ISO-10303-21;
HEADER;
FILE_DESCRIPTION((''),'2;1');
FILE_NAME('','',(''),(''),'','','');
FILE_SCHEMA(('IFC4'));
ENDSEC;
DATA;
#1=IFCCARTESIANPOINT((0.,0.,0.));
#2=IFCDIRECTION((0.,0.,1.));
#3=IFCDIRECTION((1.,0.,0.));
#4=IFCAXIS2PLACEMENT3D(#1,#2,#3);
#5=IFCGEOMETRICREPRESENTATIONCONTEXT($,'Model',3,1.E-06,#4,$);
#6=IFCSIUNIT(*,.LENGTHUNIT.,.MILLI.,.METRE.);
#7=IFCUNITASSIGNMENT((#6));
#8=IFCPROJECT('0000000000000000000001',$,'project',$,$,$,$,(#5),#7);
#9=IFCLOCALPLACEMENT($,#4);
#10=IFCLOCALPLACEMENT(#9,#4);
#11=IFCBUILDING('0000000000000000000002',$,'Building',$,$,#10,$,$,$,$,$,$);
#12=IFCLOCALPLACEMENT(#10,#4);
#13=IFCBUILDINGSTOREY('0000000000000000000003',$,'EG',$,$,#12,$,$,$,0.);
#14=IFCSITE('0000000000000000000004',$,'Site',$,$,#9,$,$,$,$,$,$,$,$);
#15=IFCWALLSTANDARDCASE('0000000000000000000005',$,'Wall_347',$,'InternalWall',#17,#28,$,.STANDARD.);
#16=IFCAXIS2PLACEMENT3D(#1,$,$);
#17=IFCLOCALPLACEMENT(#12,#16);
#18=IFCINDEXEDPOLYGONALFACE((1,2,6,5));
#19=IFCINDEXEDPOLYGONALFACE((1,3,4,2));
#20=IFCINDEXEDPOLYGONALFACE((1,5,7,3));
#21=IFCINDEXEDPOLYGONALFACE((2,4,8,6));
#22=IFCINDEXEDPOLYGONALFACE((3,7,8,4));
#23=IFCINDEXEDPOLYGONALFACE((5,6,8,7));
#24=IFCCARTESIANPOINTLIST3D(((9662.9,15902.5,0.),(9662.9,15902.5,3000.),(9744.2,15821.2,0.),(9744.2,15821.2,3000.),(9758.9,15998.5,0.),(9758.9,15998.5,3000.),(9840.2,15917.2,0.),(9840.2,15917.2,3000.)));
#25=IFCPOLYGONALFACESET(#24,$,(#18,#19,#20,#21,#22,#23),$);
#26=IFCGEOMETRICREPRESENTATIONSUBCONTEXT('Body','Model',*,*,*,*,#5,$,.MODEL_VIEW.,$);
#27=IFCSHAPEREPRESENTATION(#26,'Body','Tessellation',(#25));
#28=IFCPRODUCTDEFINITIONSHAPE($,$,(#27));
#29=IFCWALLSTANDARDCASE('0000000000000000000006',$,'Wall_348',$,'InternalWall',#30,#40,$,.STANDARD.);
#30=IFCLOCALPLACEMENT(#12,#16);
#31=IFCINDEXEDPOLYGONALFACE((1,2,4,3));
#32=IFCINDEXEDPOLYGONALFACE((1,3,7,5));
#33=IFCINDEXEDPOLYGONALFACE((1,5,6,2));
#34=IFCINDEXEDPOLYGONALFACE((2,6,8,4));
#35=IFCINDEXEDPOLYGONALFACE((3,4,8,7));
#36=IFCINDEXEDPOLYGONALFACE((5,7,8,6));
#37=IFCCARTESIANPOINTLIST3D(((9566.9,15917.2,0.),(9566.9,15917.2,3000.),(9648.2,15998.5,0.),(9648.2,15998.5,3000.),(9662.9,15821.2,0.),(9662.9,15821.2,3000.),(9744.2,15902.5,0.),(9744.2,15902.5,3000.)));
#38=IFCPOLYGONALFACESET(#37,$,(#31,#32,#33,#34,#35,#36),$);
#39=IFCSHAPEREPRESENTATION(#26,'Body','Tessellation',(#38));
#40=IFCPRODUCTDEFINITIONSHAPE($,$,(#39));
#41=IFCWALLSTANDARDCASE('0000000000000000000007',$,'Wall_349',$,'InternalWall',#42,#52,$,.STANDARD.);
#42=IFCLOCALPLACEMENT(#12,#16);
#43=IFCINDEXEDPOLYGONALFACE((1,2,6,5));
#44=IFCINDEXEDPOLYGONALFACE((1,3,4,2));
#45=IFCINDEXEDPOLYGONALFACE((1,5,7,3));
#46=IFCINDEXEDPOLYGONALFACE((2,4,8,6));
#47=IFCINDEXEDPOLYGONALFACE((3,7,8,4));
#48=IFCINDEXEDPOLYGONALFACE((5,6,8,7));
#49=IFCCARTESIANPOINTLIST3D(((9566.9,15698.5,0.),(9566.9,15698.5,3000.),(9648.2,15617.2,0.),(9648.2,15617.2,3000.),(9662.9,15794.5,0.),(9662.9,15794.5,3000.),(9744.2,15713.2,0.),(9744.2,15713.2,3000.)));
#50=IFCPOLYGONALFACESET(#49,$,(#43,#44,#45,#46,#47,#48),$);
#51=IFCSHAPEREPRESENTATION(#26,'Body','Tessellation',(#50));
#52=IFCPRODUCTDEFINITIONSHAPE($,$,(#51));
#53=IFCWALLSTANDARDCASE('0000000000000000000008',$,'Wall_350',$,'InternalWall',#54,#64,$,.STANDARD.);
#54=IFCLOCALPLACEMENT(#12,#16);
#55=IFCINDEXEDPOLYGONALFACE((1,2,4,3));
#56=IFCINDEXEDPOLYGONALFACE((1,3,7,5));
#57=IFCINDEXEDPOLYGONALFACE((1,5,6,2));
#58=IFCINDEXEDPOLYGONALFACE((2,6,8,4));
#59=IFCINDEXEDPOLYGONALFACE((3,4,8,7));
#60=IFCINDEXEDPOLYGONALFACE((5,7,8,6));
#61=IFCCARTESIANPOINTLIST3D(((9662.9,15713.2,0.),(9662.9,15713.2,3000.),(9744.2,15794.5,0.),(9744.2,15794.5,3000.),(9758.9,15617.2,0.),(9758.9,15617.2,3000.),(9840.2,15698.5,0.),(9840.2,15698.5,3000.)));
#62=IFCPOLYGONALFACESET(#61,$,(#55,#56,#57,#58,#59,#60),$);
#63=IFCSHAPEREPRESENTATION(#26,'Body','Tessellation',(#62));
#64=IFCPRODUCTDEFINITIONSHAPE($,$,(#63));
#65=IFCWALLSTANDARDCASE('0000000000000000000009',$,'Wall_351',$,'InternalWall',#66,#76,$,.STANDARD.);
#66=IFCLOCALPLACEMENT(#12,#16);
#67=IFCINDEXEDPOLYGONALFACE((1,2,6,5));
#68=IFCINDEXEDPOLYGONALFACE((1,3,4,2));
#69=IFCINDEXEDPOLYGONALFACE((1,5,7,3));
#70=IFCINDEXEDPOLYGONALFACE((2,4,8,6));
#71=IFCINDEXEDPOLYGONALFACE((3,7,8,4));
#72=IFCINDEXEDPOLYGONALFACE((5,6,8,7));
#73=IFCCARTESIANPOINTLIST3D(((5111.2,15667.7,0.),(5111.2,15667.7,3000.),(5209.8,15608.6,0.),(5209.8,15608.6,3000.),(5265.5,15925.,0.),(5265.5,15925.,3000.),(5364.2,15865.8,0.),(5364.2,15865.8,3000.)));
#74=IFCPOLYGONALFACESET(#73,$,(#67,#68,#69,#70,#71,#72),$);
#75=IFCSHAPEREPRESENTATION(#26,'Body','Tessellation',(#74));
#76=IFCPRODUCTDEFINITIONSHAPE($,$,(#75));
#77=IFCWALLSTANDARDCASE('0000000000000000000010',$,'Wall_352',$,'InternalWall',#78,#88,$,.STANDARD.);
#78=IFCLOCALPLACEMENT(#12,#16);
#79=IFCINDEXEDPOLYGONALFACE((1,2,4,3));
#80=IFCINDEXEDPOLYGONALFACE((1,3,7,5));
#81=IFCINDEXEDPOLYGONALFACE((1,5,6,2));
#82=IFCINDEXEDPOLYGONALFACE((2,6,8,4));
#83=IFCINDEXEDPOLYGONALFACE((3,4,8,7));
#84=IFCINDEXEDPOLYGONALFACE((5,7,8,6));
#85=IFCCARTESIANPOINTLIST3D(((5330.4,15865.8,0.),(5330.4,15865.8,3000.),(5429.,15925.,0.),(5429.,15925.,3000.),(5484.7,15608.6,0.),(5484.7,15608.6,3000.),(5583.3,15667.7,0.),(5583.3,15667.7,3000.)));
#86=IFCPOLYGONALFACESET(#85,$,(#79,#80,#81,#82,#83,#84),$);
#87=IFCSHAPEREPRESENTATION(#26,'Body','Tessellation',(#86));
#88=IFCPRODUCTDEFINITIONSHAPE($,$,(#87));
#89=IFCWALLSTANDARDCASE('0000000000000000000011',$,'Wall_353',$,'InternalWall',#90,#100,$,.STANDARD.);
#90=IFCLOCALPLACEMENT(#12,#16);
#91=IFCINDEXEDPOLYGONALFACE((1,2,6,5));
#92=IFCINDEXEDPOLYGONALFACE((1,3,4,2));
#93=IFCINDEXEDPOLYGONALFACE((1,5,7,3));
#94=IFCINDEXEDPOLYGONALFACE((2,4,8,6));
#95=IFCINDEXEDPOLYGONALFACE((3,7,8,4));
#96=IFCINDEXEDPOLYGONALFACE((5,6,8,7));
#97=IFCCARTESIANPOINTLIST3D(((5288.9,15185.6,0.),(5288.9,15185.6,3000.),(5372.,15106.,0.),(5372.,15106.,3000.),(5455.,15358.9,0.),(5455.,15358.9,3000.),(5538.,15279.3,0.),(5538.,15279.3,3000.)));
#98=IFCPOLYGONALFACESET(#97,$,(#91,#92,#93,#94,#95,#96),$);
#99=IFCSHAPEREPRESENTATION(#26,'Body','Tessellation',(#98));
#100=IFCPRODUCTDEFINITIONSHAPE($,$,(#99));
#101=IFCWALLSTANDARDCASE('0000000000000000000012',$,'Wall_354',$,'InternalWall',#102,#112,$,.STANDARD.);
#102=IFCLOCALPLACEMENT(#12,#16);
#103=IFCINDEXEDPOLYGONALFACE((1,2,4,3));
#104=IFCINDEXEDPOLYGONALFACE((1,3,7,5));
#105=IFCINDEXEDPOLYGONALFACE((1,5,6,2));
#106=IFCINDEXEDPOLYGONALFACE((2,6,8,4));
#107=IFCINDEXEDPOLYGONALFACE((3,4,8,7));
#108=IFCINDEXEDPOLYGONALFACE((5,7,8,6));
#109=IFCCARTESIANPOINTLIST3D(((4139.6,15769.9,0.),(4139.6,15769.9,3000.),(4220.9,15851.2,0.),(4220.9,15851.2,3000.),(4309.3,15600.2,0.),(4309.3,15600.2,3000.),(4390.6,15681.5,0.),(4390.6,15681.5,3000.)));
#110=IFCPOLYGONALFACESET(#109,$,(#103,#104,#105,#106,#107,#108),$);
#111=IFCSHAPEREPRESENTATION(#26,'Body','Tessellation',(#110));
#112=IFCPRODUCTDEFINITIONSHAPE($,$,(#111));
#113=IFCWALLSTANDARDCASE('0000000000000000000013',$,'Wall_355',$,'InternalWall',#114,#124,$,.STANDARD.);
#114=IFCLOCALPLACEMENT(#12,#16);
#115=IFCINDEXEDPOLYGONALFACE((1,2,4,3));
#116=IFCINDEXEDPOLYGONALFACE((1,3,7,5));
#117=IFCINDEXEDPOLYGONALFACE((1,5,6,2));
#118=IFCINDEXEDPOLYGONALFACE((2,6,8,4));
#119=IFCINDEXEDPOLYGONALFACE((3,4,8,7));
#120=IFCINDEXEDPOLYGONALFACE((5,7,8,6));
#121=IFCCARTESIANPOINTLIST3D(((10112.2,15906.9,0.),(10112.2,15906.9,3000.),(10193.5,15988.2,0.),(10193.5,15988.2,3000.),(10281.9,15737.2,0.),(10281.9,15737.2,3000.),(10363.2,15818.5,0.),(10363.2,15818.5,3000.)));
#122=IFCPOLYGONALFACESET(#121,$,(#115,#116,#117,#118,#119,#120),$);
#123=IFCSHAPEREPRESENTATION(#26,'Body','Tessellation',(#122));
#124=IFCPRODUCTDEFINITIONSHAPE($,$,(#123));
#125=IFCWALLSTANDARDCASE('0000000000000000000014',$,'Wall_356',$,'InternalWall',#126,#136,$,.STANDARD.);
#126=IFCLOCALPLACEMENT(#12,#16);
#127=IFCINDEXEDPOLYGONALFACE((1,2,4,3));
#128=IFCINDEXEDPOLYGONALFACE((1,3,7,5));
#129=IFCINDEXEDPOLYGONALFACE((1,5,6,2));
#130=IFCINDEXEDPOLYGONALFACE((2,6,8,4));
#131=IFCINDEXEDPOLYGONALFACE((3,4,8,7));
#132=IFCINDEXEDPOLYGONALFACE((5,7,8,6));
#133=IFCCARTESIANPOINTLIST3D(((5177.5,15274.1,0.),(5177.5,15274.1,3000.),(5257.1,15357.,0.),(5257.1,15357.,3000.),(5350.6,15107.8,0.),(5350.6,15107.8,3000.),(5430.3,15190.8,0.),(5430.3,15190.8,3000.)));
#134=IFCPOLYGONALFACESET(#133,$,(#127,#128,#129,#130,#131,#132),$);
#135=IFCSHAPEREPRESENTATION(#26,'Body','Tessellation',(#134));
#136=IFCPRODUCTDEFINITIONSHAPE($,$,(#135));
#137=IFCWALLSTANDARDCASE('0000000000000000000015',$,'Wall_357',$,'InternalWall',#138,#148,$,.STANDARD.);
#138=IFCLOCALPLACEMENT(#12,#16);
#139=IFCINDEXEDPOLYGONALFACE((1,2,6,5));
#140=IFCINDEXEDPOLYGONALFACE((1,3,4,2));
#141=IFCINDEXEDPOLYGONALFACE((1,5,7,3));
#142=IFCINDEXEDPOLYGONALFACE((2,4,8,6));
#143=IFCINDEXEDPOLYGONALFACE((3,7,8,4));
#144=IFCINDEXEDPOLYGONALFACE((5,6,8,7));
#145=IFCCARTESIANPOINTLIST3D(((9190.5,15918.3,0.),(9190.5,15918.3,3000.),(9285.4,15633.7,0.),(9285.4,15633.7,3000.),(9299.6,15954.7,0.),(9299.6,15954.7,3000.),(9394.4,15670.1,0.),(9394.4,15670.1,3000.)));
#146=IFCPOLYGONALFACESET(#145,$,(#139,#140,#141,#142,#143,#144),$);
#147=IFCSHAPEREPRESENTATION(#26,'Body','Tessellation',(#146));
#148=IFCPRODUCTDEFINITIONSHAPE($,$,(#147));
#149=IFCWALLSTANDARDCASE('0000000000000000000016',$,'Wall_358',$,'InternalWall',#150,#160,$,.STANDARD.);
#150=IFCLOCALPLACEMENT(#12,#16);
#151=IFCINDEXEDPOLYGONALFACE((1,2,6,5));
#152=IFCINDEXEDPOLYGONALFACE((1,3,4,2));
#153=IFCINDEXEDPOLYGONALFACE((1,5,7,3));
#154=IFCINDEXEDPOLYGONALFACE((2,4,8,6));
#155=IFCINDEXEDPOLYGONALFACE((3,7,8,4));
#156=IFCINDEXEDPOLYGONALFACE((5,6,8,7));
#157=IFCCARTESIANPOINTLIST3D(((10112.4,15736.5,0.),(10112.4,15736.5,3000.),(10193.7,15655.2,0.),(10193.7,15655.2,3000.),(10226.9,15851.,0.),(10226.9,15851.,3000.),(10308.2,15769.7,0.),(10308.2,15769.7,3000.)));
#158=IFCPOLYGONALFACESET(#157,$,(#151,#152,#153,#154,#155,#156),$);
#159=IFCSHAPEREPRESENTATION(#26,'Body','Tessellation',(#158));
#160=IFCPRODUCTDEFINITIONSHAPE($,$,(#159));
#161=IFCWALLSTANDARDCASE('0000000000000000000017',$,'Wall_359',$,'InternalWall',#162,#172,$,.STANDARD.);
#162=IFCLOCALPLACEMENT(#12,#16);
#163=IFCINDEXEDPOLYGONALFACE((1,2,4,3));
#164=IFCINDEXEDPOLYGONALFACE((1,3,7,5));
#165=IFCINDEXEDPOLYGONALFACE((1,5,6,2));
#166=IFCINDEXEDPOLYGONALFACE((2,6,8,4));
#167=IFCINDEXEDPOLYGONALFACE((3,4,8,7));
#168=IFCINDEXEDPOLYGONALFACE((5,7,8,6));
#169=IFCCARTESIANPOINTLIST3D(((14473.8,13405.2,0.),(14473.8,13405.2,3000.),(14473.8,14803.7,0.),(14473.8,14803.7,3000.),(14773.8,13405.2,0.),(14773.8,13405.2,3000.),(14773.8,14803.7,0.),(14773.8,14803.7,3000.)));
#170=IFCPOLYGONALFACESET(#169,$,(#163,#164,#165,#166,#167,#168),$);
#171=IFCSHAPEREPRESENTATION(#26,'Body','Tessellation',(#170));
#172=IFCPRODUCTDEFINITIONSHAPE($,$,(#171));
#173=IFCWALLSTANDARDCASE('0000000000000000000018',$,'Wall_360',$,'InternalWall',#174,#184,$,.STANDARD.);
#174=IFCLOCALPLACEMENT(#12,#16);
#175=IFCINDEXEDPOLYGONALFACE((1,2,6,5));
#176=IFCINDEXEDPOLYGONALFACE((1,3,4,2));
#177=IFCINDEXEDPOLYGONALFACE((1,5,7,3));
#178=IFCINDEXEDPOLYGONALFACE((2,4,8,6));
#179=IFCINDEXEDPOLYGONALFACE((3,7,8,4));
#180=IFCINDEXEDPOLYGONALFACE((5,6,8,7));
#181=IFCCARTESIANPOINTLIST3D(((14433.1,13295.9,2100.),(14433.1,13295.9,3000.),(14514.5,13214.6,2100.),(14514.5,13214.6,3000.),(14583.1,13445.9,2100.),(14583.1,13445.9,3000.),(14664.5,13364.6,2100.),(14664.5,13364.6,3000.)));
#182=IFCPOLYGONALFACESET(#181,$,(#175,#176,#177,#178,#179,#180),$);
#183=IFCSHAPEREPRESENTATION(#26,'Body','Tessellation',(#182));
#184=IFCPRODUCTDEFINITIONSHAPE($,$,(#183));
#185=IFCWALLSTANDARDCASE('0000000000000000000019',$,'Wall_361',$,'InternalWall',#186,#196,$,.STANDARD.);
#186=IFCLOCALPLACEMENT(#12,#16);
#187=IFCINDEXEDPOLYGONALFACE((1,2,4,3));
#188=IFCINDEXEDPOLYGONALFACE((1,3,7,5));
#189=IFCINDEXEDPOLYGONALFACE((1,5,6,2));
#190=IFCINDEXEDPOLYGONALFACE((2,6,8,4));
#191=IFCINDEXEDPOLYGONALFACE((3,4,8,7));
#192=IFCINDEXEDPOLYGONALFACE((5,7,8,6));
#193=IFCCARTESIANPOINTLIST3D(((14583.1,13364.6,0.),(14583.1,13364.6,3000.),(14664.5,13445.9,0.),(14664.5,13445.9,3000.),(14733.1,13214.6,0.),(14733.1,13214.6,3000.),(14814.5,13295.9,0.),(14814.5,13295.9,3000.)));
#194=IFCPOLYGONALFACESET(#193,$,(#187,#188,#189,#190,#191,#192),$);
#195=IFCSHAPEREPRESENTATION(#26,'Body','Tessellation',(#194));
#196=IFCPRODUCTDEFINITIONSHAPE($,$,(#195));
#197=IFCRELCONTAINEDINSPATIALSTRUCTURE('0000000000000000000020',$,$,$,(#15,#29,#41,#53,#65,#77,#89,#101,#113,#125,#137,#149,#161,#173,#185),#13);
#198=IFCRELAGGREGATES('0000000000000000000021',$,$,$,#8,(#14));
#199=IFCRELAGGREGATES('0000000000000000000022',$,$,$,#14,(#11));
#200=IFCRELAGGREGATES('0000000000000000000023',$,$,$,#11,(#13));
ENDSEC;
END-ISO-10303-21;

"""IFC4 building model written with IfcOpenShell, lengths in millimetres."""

from ifc_helpers import new_model, si_unit, frame, origin_with_axes, place, context, subcontext, project, spatial, rectangle, extrude, element, save


model = new_model("IFC4")

# Units and contexts
model_context = context("Model", 3, precision=1e-06, world=origin_with_axes())
body_context = subcontext(model_context, "Body", "Model", "MODEL_VIEW")
ifc_project = project(units=[si_unit("LENGTHUNIT", "METRE", prefix="MILLI")], contexts=[model_context])

# Site, building, storey
site_placement = place(None, origin_with_axes())
site = spatial("IfcSite", under=ifc_project, at=site_placement, Name="Site")
building_placement = place(site_placement, origin_with_axes())
building = spatial("IfcBuilding", under=site, at=building_placement, Name="Building")
storey_placement = place(building_placement, origin_with_axes())
storey = spatial("IfcBuildingStorey", under=building, at=storey_placement, Name="EG", Elevation=0.0)

# Walls
wall_1_placement = place(storey_placement, origin_with_axes())
element("IfcWallStandardCase", 1, at=wall_1_placement, inside=storey, Name="Wall_347", ObjectType="InternalWall", PredefinedType="STANDARD", context=body_context, shape_type="SweptSolid", body=[
    extrude(rectangle(XDim=135.8, YDim=115.0), frame((9751.5, 15909.9, 0.0), z_axis=(0.0, 0.0, 1.0), x_axis=(-0.707107, -0.707107, 0.0)), (0.0, 0.0, 1.0), 3000.0),
])
wall_2_placement = place(storey_placement, origin_with_axes())
element("IfcWallStandardCase", 2, at=wall_2_placement, inside=storey, Name="Wall_348", ObjectType="InternalWall", PredefinedType="STANDARD", context=body_context, shape_type="SweptSolid", body=[
    extrude(rectangle(XDim=135.8, YDim=115.0), frame((9655.5, 15909.9, 0.0), z_axis=(0.0, 0.0, 1.0), x_axis=(-0.707107, 0.707107, 0.0)), (0.0, 0.0, 1.0), 3000.0),
])
wall_3_placement = place(storey_placement, origin_with_axes())
element("IfcWallStandardCase", 3, at=wall_3_placement, inside=storey, Name="Wall_349", ObjectType="InternalWall", PredefinedType="STANDARD", context=body_context, shape_type="SweptSolid", body=[
    extrude(rectangle(XDim=135.8, YDim=115.0), frame((9655.5, 15705.9, 0.0), z_axis=(0.0, 0.0, 1.0), x_axis=(-0.707107, -0.707107, 0.0)), (0.0, 0.0, 1.0), 3000.0),
])
wall_4_placement = place(storey_placement, origin_with_axes())
element("IfcWallStandardCase", 4, at=wall_4_placement, inside=storey, Name="Wall_350", ObjectType="InternalWall", PredefinedType="STANDARD", context=body_context, shape_type="SweptSolid", body=[
    extrude(rectangle(XDim=135.8, YDim=115.0), frame((9751.5, 15705.9, 0.0), z_axis=(0.0, 0.0, 1.0), x_axis=(0.707107, -0.707107, 0.0)), (0.0, 0.0, 1.0), 3000.0),
])
wall_5_placement = place(storey_placement, origin_with_axes())
element("IfcWallStandardCase", 5, at=wall_5_placement, inside=storey, Name="Wall_351", ObjectType="InternalWall", PredefinedType="STANDARD", context=body_context, shape_type="SweptSolid", body=[
    extrude(rectangle(XDim=300.0, YDim=115.0), frame((5237.7, 15766.8, 0.0), z_axis=(0.0, 0.0, 1.0), x_axis=(0.514496, 0.857493, 0.0)), (0.0, 0.0, 1.0), 3000.0),
])
wall_6_placement = place(storey_placement, origin_with_axes())
element("IfcWallStandardCase", 6, at=wall_6_placement, inside=storey, Name="Wall_352", ObjectType="InternalWall", PredefinedType="STANDARD", context=body_context, shape_type="SweptSolid", body=[
    extrude(rectangle(XDim=300.0, YDim=115.0), frame((5456.8, 15766.8, 0.0), z_axis=(0.0, 0.0, 1.0), x_axis=(-0.514496, 0.857493, 0.0)), (0.0, 0.0, 1.0), 3000.0),
])
wall_7_placement = place(storey_placement, origin_with_axes())
element("IfcWallStandardCase", 7, at=wall_7_placement, inside=storey, Name="Wall_353", ObjectType="InternalWall", PredefinedType="STANDARD", context=body_context, shape_type="SweptSolid", body=[
    extrude(rectangle(XDim=240.0, YDim=115.0), frame((5413.5, 15232.4, 0.0), z_axis=(0.0, 0.0, 1.0), x_axis=(0.69185, 0.722042, 0.0)), (0.0, 0.0, 1.0), 3000.0),
])
wall_8_placement = place(storey_placement, origin_with_axes())
element("IfcWallStandardCase", 8, at=wall_8_placement, inside=storey, Name="Wall_354", ObjectType="InternalWall", PredefinedType="STANDARD", context=body_context, shape_type="SweptSolid", body=[
    extrude(rectangle(XDim=240.0, YDim=115.0), frame((4265.1, 15725.7, 0.0), z_axis=(0.0, 0.0, 1.0), x_axis=(0.707107, -0.707107, 0.0)), (0.0, 0.0, 1.0), 3000.0),
])
wall_9_placement = place(storey_placement, origin_with_axes())
element("IfcWallStandardCase", 9, at=wall_9_placement, inside=storey, Name="Wall_355", ObjectType="InternalWall", PredefinedType="STANDARD", context=body_context, shape_type="SweptSolid", body=[
    extrude(rectangle(XDim=240.0, YDim=115.0), frame((10237.7, 15862.7, 0.0), z_axis=(0.0, 0.0, 1.0), x_axis=(-0.707107, 0.707107, 0.0)), (0.0, 0.0, 1.0), 3000.0),
])
wall_10_placement = place(storey_placement, origin_with_axes())
element("IfcWallStandardCase", 10, at=wall_10_placement, inside=storey, Name="Wall_356", ObjectType="InternalWall", PredefinedType="STANDARD", context=body_context, shape_type="SweptSolid", body=[
    extrude(rectangle(XDim=240.0, YDim=115.0), frame((5303.9, 15232.4, 0.0), z_axis=(0.0, 0.0, 1.0), x_axis=(-0.721334, 0.692587, 0.0)), (0.0, 0.0, 1.0), 3000.0),
])
wall_11_placement = place(storey_placement, origin_with_axes())
element("IfcWallStandardCase", 11, at=wall_11_placement, inside=storey, Name="Wall_357", ObjectType="InternalWall", PredefinedType="STANDARD", context=body_context, shape_type="SweptSolid", body=[
    extrude(rectangle(XDim=300.0, YDim=115.0), frame((9292.5, 15794.2, 0.0), z_axis=(0.0, 0.0, 1.0), x_axis=(-0.316228, 0.948683, 0.0)), (0.0, 0.0, 1.0), 3000.0),
])
wall_12_placement = place(storey_placement, origin_with_axes())
element("IfcWallStandardCase", 12, at=wall_12_placement, inside=storey, Name="Wall_358", ObjectType="InternalWall", PredefinedType="STANDARD", context=body_context, shape_type="SweptSolid", body=[
    extrude(rectangle(XDim=161.9, YDim=115.0), frame((10210.3, 15753.1, 0.0), z_axis=(0.0, 0.0, 1.0), x_axis=(-0.707107, -0.707107, 0.0)), (0.0, 0.0, 1.0), 3000.0),
])
wall_13_placement = place(storey_placement, origin_with_axes())
element("IfcWallStandardCase", 13, at=wall_13_placement, inside=storey, Name="Wall_359", ObjectType="InternalWall", PredefinedType="STANDARD", context=body_context, shape_type="SweptSolid", body=[
    extrude(rectangle(XDim=1398.5, YDim=300.0), frame((14623.8, 14104.5, 0.0), z_axis=(0.0, 0.0, 1.0), x_axis=(0.0, 1.0, 0.0)), (0.0, 0.0, 1.0), 3000.0),
])

# Wall, opening
wall_14_placement = place(storey_placement, origin_with_axes())
wall_14 = element("IfcWallStandardCase", 14, at=wall_14_placement, inside=storey, Name="Wall_360", ObjectType="InternalWall", PredefinedType="STANDARD", context=body_context, shape_type="SweptSolid", body=[
    extrude(rectangle(XDim=212.1, YDim=115.0), frame((14548.8, 13330.2, 0.0), z_axis=(0.0, 0.0, 1.0), x_axis=(-0.707107, -0.707107, 0.0)), (0.0, 0.0, 1.0), 3000.0),
])
opening_placement = place(wall_14_placement, origin_with_axes())
element("IfcOpeningElement", 15, at=opening_placement, inside=storey, cuts=wall_14, context=body_context, shape_type="SweptSolid", body=[
    extrude(rectangle(XDim=799.9, YDim=115.0), frame((14494.2, 13275.6, 0.0), z_axis=(0.0, 0.0, 1.0), x_axis=(-0.707107, -0.707107, 0.0)), (0.0, 0.0, 1.0), 2100.0),
])

# Wall
wall_15_placement = place(storey_placement, origin_with_axes())
element("IfcWallStandardCase", 16, at=wall_15_placement, inside=storey, Name="Wall_361", ObjectType="InternalWall", PredefinedType="STANDARD", context=body_context, shape_type="SweptSolid", body=[
    extrude(rectangle(XDim=212.1, YDim=115.0), frame((14698.8, 13330.2, 0.0), z_axis=(0.0, 0.0, 1.0), x_axis=(0.707107, -0.707107, 0.0)), (0.0, 0.0, 1.0), 3000.0),
])

save(model, "model.ifc")
